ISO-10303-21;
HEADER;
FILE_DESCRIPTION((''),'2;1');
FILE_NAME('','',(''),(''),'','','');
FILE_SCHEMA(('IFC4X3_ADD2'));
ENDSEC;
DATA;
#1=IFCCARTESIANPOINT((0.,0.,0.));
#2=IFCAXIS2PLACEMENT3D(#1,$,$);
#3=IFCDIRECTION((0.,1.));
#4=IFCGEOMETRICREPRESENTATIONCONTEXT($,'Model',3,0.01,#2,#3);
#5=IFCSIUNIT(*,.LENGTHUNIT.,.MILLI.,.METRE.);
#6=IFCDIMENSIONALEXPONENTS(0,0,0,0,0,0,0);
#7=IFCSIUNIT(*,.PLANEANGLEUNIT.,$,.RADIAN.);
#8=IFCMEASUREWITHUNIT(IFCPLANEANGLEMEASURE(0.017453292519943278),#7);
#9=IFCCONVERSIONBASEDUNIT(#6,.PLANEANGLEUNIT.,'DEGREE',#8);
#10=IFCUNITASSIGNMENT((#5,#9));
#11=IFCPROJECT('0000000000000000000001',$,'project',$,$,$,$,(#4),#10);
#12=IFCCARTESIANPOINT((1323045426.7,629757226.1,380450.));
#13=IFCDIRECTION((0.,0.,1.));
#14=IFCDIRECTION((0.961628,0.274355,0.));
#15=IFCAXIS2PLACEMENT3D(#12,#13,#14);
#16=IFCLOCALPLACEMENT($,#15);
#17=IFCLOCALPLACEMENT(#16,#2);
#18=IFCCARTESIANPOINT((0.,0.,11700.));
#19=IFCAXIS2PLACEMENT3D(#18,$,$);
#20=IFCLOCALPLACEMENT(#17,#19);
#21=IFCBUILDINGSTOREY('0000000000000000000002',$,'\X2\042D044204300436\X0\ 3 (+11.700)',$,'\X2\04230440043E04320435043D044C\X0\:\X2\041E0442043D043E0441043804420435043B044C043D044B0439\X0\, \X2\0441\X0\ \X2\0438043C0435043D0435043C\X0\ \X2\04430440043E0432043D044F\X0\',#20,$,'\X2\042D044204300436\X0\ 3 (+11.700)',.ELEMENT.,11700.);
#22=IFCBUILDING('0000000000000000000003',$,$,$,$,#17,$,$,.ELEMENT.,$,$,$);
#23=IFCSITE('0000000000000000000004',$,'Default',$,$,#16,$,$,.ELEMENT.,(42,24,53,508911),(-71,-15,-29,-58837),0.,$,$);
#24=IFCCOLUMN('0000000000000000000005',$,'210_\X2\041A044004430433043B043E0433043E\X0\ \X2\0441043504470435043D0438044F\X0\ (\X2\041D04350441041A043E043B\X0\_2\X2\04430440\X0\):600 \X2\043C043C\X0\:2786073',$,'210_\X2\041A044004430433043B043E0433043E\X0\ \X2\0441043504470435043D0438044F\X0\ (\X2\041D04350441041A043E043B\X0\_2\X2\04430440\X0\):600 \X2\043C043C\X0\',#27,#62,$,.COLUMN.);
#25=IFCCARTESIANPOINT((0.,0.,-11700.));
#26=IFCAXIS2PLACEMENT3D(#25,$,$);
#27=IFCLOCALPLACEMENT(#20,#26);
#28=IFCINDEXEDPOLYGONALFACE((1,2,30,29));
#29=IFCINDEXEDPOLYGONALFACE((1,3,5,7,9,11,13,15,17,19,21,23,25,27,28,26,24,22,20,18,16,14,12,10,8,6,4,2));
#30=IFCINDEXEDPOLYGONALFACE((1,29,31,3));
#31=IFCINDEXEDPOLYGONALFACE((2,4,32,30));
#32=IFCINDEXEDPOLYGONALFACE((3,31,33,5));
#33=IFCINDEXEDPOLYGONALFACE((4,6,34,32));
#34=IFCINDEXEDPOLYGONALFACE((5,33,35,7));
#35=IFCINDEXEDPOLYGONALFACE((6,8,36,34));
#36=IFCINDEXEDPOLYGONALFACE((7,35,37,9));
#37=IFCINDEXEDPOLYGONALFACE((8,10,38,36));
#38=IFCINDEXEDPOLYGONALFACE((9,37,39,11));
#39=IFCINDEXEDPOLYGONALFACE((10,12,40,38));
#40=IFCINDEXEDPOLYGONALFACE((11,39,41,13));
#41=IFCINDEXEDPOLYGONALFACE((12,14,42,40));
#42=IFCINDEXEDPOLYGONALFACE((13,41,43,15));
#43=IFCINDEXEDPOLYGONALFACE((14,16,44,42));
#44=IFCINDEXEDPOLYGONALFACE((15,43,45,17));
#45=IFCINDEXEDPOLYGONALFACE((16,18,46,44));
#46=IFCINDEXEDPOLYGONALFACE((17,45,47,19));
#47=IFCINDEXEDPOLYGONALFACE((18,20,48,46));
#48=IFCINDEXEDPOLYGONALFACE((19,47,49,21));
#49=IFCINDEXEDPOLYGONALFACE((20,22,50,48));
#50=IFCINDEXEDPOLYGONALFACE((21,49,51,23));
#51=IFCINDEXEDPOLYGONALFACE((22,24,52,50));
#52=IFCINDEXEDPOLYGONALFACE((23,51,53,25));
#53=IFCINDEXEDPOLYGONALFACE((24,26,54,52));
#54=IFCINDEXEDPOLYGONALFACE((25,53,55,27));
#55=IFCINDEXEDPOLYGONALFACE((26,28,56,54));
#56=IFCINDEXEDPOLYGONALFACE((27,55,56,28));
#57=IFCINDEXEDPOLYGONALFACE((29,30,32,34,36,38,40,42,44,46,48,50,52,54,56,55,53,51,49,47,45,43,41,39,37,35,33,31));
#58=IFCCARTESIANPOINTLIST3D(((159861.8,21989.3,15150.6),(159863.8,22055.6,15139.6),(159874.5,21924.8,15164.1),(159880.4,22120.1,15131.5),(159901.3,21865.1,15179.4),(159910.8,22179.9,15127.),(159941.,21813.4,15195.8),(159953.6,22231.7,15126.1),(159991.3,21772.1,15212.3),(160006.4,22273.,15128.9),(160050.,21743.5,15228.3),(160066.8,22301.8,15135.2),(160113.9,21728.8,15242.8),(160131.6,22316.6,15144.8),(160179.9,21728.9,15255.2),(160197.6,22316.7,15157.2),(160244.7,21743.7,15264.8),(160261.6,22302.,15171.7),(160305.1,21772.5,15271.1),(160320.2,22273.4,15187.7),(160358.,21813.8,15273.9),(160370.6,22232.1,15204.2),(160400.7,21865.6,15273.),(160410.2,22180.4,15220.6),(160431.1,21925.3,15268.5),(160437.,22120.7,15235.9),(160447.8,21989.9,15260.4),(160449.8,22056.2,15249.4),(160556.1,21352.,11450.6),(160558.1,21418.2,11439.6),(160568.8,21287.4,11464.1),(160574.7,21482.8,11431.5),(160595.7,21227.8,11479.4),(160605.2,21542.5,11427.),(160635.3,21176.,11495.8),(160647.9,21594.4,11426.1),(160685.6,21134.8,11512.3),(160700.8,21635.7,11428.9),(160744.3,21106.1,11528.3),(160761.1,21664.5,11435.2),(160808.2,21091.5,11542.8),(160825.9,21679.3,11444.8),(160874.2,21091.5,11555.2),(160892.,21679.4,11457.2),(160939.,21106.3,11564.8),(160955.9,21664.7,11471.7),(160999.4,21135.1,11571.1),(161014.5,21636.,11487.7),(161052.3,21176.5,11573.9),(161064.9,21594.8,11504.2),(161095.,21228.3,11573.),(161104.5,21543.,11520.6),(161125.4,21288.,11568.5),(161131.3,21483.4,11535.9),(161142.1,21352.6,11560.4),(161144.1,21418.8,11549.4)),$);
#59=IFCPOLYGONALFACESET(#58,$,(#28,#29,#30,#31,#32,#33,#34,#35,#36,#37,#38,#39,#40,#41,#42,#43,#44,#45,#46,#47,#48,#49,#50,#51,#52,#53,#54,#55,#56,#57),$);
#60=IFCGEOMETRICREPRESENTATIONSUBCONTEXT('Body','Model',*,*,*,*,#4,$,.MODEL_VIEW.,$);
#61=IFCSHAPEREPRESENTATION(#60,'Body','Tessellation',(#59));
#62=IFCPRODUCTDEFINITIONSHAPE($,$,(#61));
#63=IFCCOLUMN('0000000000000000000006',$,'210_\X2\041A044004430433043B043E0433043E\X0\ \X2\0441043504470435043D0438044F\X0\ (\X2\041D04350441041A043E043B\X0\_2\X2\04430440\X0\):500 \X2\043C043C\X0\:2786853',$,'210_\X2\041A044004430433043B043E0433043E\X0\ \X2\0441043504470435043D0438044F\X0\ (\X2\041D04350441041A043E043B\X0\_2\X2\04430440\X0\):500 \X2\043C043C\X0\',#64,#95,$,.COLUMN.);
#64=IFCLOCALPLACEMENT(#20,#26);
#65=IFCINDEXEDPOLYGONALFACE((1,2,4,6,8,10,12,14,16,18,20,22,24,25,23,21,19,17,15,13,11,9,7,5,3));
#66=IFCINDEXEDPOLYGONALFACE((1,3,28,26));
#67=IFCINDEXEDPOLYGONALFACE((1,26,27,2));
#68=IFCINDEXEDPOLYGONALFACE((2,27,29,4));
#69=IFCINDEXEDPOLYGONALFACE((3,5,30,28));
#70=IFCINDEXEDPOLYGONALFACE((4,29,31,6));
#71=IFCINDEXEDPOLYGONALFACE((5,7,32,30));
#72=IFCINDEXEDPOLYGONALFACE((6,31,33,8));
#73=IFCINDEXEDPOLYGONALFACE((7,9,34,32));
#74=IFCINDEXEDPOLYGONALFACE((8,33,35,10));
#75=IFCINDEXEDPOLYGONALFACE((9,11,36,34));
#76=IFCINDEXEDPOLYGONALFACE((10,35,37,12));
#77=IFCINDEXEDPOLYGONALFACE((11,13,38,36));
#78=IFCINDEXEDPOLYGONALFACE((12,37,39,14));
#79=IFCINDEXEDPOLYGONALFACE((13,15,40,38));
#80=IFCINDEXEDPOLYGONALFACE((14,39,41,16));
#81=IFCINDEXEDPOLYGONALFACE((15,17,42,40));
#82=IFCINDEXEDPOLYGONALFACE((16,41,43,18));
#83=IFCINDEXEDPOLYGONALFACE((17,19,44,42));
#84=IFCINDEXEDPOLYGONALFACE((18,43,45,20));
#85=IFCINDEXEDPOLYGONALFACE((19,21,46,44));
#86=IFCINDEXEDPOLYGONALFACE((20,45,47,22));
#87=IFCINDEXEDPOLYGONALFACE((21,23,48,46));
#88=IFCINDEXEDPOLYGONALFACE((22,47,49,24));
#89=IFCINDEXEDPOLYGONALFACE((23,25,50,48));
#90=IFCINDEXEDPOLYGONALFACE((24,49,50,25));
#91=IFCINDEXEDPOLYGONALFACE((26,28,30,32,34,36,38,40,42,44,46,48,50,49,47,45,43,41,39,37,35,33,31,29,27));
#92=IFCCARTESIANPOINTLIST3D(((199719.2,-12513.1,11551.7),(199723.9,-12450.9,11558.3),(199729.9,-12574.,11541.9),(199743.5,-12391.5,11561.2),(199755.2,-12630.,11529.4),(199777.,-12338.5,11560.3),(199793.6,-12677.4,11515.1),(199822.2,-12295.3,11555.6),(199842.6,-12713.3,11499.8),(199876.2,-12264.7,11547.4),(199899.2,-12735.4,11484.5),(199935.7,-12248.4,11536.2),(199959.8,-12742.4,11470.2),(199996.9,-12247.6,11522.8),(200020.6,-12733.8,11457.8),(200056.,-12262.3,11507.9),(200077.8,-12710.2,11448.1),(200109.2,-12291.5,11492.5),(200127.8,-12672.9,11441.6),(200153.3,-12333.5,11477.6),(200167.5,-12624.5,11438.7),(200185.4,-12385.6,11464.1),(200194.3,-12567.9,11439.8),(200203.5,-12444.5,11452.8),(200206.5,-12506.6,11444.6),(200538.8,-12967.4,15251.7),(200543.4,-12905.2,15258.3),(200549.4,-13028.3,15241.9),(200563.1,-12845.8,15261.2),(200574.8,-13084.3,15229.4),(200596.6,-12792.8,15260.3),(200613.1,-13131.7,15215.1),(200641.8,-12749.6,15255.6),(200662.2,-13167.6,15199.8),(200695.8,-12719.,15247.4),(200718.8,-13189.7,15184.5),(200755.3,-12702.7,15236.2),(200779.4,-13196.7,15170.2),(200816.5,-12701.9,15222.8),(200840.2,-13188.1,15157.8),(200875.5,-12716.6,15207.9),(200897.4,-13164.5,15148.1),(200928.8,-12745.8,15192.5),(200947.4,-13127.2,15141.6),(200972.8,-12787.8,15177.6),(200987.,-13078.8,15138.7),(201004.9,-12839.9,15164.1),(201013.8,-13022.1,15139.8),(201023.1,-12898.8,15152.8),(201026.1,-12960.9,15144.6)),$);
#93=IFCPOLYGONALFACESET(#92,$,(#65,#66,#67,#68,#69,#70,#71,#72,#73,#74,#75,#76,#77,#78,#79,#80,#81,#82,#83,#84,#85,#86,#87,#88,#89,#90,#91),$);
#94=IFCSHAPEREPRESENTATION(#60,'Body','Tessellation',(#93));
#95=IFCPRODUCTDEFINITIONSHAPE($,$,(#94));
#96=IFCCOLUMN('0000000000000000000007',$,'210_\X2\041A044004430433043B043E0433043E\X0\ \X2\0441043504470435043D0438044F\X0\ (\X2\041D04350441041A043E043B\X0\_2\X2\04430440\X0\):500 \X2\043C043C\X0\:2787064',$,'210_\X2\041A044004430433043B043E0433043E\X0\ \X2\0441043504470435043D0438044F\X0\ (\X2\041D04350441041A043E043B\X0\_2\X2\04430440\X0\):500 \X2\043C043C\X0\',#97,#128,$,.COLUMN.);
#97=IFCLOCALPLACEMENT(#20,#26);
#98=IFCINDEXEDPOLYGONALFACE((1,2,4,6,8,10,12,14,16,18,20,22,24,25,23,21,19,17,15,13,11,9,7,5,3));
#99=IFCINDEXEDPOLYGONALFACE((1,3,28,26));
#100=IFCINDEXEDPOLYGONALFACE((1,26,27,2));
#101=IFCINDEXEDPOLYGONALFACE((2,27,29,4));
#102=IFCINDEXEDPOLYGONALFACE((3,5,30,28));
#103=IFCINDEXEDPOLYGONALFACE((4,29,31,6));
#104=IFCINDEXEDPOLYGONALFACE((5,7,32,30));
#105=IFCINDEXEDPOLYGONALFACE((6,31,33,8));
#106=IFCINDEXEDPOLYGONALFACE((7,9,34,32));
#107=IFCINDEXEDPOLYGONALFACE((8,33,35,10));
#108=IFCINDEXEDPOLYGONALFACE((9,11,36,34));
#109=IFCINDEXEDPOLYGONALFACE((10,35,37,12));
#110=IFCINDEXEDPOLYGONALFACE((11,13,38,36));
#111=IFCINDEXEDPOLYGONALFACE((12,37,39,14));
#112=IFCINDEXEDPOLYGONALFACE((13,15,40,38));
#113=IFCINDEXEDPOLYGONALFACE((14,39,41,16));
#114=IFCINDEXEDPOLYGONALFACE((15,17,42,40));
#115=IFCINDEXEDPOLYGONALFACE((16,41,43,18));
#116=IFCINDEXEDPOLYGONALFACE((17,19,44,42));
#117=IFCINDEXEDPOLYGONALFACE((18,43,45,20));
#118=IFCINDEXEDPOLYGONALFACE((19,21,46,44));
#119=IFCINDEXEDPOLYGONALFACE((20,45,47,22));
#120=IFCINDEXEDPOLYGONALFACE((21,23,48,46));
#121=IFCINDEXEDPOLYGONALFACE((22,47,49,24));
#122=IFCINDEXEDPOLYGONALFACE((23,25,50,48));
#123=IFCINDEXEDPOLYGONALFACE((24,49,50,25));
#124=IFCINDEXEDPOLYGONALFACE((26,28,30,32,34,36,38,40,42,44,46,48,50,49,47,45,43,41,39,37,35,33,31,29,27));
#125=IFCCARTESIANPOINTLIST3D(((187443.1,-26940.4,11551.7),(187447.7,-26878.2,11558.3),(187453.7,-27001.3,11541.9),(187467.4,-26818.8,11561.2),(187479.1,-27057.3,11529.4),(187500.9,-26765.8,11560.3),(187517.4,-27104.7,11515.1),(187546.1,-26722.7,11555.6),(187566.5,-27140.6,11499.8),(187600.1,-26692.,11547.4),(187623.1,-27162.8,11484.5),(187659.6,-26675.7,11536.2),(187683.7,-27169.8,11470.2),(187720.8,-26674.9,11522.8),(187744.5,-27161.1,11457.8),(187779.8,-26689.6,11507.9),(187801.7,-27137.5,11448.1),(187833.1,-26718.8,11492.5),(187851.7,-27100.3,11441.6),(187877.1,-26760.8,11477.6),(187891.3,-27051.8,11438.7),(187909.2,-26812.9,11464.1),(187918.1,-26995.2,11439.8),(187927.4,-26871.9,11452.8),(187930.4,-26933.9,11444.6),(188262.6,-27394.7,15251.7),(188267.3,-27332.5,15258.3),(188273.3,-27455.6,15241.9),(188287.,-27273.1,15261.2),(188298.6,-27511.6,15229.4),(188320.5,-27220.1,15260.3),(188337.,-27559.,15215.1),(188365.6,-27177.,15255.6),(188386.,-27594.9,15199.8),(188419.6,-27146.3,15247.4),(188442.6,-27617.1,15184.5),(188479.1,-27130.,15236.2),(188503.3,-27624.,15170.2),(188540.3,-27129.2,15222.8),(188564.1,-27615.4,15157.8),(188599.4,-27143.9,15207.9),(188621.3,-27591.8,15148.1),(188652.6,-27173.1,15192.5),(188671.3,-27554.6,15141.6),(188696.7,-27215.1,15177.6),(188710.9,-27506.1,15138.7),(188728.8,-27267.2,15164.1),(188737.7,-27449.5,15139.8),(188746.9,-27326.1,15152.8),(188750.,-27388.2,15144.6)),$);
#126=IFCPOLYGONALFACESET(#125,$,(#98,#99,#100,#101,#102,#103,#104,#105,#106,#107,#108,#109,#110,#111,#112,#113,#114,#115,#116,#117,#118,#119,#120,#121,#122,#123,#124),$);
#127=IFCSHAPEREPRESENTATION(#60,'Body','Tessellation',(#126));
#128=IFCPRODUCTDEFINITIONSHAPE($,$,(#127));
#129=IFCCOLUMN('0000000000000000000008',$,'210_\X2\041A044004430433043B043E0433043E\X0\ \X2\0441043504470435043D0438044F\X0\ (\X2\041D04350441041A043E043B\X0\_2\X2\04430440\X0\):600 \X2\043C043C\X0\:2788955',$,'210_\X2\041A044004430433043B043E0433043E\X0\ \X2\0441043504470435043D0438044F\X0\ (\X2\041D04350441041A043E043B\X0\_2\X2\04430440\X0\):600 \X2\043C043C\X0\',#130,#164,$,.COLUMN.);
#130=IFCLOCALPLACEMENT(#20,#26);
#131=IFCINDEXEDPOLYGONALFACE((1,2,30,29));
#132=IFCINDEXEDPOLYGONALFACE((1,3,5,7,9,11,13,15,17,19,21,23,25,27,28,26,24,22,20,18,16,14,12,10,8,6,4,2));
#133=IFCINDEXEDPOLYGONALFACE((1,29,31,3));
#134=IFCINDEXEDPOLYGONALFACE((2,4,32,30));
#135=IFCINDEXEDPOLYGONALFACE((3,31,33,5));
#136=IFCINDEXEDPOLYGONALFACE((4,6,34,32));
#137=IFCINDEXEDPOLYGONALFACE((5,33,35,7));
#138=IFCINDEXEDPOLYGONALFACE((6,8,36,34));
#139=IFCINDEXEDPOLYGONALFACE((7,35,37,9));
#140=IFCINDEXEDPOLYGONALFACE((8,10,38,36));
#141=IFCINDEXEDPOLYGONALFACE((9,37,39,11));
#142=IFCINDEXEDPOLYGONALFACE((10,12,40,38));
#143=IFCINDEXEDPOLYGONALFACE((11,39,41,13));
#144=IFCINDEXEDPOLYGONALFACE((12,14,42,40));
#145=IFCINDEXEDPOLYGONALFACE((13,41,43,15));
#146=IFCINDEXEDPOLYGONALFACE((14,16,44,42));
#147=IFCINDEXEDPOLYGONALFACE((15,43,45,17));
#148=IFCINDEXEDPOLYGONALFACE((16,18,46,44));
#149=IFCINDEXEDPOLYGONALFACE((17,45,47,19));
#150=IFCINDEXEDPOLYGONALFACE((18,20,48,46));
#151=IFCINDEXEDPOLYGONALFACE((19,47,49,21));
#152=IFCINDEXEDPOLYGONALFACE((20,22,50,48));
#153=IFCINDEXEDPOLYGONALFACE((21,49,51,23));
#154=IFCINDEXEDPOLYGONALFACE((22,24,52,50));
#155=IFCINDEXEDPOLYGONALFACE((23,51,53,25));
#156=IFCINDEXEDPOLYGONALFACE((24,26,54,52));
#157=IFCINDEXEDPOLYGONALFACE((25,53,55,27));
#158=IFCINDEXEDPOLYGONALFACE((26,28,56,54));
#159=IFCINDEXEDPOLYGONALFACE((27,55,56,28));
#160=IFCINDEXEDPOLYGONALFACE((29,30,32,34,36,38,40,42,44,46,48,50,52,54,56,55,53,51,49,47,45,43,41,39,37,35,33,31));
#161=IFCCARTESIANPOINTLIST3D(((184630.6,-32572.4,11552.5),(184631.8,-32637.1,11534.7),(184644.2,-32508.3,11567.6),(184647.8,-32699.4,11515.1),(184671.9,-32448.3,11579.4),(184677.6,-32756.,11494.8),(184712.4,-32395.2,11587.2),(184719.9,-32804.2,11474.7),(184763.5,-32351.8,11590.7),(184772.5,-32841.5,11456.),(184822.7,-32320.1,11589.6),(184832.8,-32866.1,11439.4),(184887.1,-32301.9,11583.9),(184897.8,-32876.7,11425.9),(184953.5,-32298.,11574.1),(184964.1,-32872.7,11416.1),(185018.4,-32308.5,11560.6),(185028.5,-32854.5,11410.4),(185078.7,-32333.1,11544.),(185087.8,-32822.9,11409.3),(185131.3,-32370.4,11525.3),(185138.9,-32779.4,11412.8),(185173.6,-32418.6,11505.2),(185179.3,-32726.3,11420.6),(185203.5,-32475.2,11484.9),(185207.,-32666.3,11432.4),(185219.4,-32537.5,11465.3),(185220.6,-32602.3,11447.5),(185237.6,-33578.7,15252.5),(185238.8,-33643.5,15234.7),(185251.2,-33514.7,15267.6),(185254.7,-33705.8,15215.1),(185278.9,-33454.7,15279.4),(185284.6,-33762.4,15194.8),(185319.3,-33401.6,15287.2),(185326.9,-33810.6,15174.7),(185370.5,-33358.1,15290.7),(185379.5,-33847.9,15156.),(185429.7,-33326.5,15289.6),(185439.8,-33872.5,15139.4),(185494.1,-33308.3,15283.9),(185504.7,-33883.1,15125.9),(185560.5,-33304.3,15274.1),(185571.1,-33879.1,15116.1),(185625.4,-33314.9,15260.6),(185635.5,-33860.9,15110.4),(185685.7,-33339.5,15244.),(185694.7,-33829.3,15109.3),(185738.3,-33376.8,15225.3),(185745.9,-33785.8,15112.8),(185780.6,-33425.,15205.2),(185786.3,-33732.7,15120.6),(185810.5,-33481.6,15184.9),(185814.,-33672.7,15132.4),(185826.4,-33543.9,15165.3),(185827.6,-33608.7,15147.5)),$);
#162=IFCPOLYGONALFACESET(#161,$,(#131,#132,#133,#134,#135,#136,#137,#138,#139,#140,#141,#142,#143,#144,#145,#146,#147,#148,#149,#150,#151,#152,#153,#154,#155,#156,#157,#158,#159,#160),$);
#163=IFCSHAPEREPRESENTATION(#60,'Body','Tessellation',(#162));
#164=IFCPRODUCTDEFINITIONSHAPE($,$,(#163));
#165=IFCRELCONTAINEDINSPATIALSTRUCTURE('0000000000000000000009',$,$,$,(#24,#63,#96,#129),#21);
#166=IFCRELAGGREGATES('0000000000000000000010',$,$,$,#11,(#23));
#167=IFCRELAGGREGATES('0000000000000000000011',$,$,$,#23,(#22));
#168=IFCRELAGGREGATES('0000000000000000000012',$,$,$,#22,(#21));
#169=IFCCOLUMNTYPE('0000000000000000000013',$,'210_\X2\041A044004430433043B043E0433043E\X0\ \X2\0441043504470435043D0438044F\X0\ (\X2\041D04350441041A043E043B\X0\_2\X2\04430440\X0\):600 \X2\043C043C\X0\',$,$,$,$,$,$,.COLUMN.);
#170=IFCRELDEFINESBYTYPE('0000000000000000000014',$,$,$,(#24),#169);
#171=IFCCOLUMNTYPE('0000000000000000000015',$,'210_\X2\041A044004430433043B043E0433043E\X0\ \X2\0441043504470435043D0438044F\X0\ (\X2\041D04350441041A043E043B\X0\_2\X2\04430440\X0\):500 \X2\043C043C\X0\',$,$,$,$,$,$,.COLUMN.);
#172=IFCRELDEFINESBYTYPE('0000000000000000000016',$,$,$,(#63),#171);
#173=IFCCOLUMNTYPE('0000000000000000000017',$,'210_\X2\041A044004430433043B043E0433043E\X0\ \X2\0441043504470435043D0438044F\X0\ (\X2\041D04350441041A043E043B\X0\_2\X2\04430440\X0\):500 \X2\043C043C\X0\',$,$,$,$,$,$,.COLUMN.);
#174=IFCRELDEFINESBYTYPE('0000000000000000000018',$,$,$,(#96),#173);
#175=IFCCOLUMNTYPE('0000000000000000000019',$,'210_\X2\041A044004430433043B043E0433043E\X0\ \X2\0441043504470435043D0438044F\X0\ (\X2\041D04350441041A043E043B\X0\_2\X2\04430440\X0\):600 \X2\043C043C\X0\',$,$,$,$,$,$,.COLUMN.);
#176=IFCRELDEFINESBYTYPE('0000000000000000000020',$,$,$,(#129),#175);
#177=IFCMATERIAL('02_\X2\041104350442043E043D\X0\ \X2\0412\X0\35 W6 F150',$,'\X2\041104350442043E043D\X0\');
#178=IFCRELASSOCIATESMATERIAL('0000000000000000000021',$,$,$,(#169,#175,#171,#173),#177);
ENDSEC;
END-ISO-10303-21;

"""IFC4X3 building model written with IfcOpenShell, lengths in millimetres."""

from ifc_helpers import new_model, entity, si_unit, converted_unit, direction, frame, frame_2d, origin, origin_2d_with_axis, place, context, subcontext, project, spatial, circle, extrude, source, transform, mapped, material, material_profile, profile_set, type_object, type_shapes, element, save


model = new_model("IFC4X3")

# Units and contexts
model_context = context("Model", 3, precision=0.01, world=origin(), true_north=direction((0.0, 1.0)))
body_context = subcontext(model_context, "Body", "Model", "MODEL_VIEW")
ifc_project = project(units=[si_unit("LENGTHUNIT", "METRE", prefix="MILLI"), converted_unit("PLANEANGLEUNIT", "DEGREE", entity("IfcPlaneAngleMeasure", 0.017453292519943278), si_unit("PLANEANGLEUNIT", "RADIAN"), dimensions=[0, 0, 0, 0, 0, 0, 0])], contexts=[model_context])

# Site, building, storey
site_placement = place(None, frame((1323045426.7, 629757226.1, 380450.0), z_axis=(0.0, 0.0, 1.0), x_axis=(0.961628, 0.274355, 0.0)))
site = spatial("IfcSite", under=ifc_project, at=site_placement, Name="Default", CompositionType="ELEMENT", RefLatitude=(42, 24, 53, 508911), RefLongitude=(-71, -15, -29, -58837), RefElevation=0.0)
building_placement = place(site_placement, origin())
building = spatial("IfcBuilding", under=site, at=building_placement, CompositionType="ELEMENT")
storey_placement = place(building_placement, frame((0.0, 0.0, 11700.0)))
storey = spatial("IfcBuildingStorey", under=building, at=storey_placement, Name="Этаж 3 (+11.700)", ObjectType="Уровень:Относительный, с именем уровня", LongName="Этаж 3 (+11.700)", CompositionType="ELEMENT", Elevation=11700.0)

# Columns
ifc_material_1 = material(Name="02_Бетон В35 W6 F150", Category="Бетон")
ifc_material_profile_1 = material_profile(ifc_material_1, circle(Radius=300.0, at=origin_2d_with_axis()), Name="600 мм")
ifc_profile_set_1 = profile_set([ifc_material_profile_1], Name="600 мм")
ifc_material_profile_2 = material_profile(ifc_material_1, circle(Radius=250.0, at=origin_2d_with_axis()), Name="500 мм")
ifc_profile_set_2 = profile_set([ifc_material_profile_2], Name="500 мм")
column_type_1 = type_object("IfcColumnType", Name="210_Круглого сечения (НесКол_2ур):600 мм", PredefinedType="COLUMN", material=ifc_profile_set_1)
shared_shape_1 = source(origin(), body_context, "Body", "SweptSolid", [
    extrude(circle(Radius=300.0, at=frame_2d((0.0, 0.0), x_axis=(1.0, 0.0))), frame((160850.1, 21385.4, 11500.0), z_axis=(-0.181845, 0.166921, 0.969056), x_axis=(-0.937548, -0.326623, -0.119671)), (0.0, 0.0, 1.0), 3818.1),
])
type_shapes(column_type_1, [shared_shape_1])
column_1_placement = place(storey_placement, frame((0.0, 0.0, -11700.0)))
element("IfcColumn", 1, at=column_1_placement, inside=storey, type_object=column_type_1, Name="210_Круглого сечения (НесКол_2ур):600 мм:2786073", ObjectType="210_Круглого сечения (НесКол_2ур):600 мм", PredefinedType="COLUMN", context=body_context, shape_type="MappedRepresentation", body=[
    mapped(shared_shape_1, transform((0.0, 0.0, 0.0), scale=1.0)),
])
column_type_2 = type_object("IfcColumnType", Name="210_Круглого сечения (НесКол_2ур):500 мм", PredefinedType="COLUMN", material=ifc_profile_set_2)
shared_shape_2 = source(origin(), body_context, "Body", "SweptSolid", [
    extrude(circle(Radius=250.0, at=frame_2d((0.0, 0.0), x_axis=(1.0, 0.0))), frame((199963.1, -12494.2, 11500.0), z_axis=(0.214726, -0.119025, 0.969395), x_axis=(-0.012977, -0.992806, -0.119025)), (0.0, 0.0, 1.0), 3816.8),
])
type_shapes(column_type_2, [shared_shape_2])
column_2_placement = place(storey_placement, frame((0.0, 0.0, -11700.0)))
element("IfcColumn", 2, at=column_2_placement, inside=storey, type_object=column_type_2, Name="210_Круглого сечения (НесКол_2ур):500 мм:2786853", ObjectType="210_Круглого сечения (НесКол_2ур):500 мм", PredefinedType="COLUMN", context=body_context, shape_type="MappedRepresentation", body=[
    mapped(shared_shape_2, transform((0.0, 0.0, 0.0), scale=1.0)),
])
column_type_3 = type_object("IfcColumnType", Name="210_Круглого сечения (НесКол_2ур):500 мм", PredefinedType="COLUMN", material=ifc_profile_set_2)
shared_shape_3 = source(origin(), body_context, "Body", "SweptSolid", [
    extrude(circle(Radius=250.0, at=origin_2d_with_axis()), frame((187686.9, -26921.5, 11500.0), z_axis=(0.214726, -0.119025, 0.969395), x_axis=(-0.012977, -0.992806, -0.119025)), (0.0, 0.0, 1.0), 3816.8),
])
type_shapes(column_type_3, [shared_shape_3])
column_3_placement = place(storey_placement, frame((0.0, 0.0, -11700.0)))
element("IfcColumn", 3, at=column_3_placement, inside=storey, type_object=column_type_3, Name="210_Круглого сечения (НесКол_2ур):500 мм:2787064", ObjectType="210_Круглого сечения (НесКол_2ур):500 мм", PredefinedType="COLUMN", context=body_context, shape_type="MappedRepresentation", body=[
    mapped(shared_shape_3, transform((0.0, 0.0, 0.0), scale=1.0)),
])
column_type_4 = type_object("IfcColumnType", Name="210_Круглого сечения (НесКол_2ур):600 мм", PredefinedType="COLUMN", material=ifc_profile_set_1)
shared_shape_4 = source(origin(), body_context, "Body", "SweptSolid", [
    extrude(circle(Radius=300.0, at=frame_2d((0.0, 0.0), x_axis=(1.0, 0.0))), frame((184925.6, -32587.3, 11500.0), z_axis=(0.15635, -0.259232, 0.953076), x_axis=(0.510309, 0.847375, 0.146767)), (0.0, 0.0, 1.0), 3882.2),
])
type_shapes(column_type_4, [shared_shape_4])
column_4_placement = place(storey_placement, frame((0.0, 0.0, -11700.0)))
element("IfcColumn", 4, at=column_4_placement, inside=storey, type_object=column_type_4, Name="210_Круглого сечения (НесКол_2ур):600 мм:2788955", ObjectType="210_Круглого сечения (НесКол_2ур):600 мм", PredefinedType="COLUMN", context=body_context, shape_type="MappedRepresentation", body=[
    mapped(shared_shape_4, transform((0.0, 0.0, 0.0), scale=1.0)),
])

save(model, "model.ifc")
